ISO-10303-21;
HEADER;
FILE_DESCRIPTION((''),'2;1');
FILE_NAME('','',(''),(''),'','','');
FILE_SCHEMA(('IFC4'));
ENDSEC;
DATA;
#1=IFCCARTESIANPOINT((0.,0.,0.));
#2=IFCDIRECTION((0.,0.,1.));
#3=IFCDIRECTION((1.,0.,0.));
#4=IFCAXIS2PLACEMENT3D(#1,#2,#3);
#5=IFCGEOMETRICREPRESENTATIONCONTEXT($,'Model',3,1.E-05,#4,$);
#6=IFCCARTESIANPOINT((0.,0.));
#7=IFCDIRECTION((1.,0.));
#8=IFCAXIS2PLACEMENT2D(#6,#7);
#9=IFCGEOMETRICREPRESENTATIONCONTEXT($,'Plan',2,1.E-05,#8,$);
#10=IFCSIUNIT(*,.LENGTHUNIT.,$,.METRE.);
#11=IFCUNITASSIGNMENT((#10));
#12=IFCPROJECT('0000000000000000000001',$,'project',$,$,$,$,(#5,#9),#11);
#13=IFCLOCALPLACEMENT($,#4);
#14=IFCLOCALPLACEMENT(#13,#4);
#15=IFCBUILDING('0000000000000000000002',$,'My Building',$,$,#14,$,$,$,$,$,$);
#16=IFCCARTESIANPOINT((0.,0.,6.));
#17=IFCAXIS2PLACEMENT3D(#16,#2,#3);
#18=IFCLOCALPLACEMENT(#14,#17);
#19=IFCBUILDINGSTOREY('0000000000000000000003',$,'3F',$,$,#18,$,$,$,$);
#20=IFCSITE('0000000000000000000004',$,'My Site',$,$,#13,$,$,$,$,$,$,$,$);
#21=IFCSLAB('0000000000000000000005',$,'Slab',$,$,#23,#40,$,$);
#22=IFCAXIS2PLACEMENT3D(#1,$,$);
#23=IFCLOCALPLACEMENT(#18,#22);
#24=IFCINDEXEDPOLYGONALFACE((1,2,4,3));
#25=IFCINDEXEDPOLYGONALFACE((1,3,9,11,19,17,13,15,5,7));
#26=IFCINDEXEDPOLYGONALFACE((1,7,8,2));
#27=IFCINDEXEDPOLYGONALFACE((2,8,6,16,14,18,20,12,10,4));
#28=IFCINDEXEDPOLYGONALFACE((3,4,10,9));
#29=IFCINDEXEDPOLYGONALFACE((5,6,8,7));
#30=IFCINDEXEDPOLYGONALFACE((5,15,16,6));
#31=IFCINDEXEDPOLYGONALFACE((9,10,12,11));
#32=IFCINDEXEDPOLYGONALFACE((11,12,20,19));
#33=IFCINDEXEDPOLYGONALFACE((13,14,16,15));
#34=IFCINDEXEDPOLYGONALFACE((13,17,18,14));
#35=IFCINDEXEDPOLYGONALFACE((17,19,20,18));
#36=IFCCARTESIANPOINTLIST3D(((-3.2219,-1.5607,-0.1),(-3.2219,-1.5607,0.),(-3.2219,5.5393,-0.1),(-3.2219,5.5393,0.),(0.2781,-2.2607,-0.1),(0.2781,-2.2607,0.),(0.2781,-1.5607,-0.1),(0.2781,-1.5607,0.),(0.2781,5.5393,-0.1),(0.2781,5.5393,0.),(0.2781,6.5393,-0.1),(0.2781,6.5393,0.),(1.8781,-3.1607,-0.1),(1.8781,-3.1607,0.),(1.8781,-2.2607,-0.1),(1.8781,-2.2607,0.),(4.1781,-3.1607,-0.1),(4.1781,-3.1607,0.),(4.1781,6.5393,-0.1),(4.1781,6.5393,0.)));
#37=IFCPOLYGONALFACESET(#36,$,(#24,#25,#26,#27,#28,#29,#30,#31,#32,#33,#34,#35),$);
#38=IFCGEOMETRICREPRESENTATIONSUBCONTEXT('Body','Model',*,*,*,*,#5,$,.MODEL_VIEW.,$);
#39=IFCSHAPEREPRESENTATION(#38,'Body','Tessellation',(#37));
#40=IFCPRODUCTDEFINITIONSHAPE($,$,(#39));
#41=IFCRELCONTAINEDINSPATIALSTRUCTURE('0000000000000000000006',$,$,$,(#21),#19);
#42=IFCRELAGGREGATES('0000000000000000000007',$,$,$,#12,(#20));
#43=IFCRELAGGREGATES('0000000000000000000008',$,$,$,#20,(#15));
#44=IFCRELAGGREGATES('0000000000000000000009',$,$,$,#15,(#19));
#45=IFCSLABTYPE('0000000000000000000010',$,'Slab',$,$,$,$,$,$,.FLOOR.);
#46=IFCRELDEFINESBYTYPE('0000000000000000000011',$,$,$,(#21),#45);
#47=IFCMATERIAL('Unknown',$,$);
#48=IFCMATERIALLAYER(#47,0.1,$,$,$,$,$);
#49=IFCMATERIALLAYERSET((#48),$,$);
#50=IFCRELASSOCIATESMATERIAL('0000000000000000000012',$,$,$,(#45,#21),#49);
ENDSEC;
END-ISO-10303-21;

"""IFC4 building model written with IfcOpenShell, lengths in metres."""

from ifc_helpers import new_model, si_unit, frame, origin_with_axes, origin_2d_with_axis, place, context, subcontext, project, spatial, indexed_curve, outline, extrude, material, layer, layer_set, layer_usage, type_object, element, save


model = new_model("IFC4")

# Units and contexts
model_context = context("Model", 3, precision=1e-05, world=origin_with_axes())
plan_context = context("Plan", 2, precision=1e-05, world=origin_2d_with_axis())
body_context = subcontext(model_context, "Body", "Model", "MODEL_VIEW")
ifc_project = project(units=[si_unit("LENGTHUNIT", "METRE")], contexts=[model_context, plan_context])

# Site, building, storey
site_placement = place(None, origin_with_axes())
site = spatial("IfcSite", under=ifc_project, at=site_placement, Name="My Site")
building_placement = place(site_placement, origin_with_axes())
building = spatial("IfcBuilding", under=site, at=building_placement, Name="My Building")
storey_placement = place(building_placement, frame((0.0, 0.0, 6.0), z_axis=(0.0, 0.0, 1.0), x_axis=(1.0, 0.0, 0.0)))
storey = spatial("IfcBuildingStorey", under=building, at=storey_placement, Name="3F")

# Slab
ifc_material = material(Name="Unknown")
ifc_layer = layer(ifc_material, 0.1)
ifc_layer_set = layer_set([ifc_layer])
ifc_layer_usage = layer_usage(ifc_layer_set, "AXIS3", "POSITIVE", -0.1)
slab_type = type_object("IfcSlabType", Name="Slab", PredefinedType="FLOOR", material=ifc_layer_set)
slab_placement = place(storey_placement, frame((4.1781, -3.1607, 0.0), z_axis=(0.0, 0.0, 1.0), x_axis=(1.0, 0.0, 0.0)))
element("IfcSlab", 1, at=slab_placement, inside=storey, type_object=slab_type, material=ifc_layer_usage, Name="Slab", context=body_context, shape_type="SweptSolid", body=[
    extrude(outline(indexed_curve([(0.0, 0.0), (0.0, 9.7), (-3.9, 9.7), (-3.9, 8.7), (-7.4, 8.7), (-7.4, 1.6), (-3.9, 1.6), (-3.9, 0.9), (-2.3, 0.9), (-2.3, 0.0), (0.0, 0.0)])), frame((0.0, 0.0, -0.1), z_axis=(0.0, 0.0, 1.0), x_axis=(1.0, 0.0, 0.0)), (0.0, 0.0, 1.0), 0.1),
])

save(model, "model.ifc")
